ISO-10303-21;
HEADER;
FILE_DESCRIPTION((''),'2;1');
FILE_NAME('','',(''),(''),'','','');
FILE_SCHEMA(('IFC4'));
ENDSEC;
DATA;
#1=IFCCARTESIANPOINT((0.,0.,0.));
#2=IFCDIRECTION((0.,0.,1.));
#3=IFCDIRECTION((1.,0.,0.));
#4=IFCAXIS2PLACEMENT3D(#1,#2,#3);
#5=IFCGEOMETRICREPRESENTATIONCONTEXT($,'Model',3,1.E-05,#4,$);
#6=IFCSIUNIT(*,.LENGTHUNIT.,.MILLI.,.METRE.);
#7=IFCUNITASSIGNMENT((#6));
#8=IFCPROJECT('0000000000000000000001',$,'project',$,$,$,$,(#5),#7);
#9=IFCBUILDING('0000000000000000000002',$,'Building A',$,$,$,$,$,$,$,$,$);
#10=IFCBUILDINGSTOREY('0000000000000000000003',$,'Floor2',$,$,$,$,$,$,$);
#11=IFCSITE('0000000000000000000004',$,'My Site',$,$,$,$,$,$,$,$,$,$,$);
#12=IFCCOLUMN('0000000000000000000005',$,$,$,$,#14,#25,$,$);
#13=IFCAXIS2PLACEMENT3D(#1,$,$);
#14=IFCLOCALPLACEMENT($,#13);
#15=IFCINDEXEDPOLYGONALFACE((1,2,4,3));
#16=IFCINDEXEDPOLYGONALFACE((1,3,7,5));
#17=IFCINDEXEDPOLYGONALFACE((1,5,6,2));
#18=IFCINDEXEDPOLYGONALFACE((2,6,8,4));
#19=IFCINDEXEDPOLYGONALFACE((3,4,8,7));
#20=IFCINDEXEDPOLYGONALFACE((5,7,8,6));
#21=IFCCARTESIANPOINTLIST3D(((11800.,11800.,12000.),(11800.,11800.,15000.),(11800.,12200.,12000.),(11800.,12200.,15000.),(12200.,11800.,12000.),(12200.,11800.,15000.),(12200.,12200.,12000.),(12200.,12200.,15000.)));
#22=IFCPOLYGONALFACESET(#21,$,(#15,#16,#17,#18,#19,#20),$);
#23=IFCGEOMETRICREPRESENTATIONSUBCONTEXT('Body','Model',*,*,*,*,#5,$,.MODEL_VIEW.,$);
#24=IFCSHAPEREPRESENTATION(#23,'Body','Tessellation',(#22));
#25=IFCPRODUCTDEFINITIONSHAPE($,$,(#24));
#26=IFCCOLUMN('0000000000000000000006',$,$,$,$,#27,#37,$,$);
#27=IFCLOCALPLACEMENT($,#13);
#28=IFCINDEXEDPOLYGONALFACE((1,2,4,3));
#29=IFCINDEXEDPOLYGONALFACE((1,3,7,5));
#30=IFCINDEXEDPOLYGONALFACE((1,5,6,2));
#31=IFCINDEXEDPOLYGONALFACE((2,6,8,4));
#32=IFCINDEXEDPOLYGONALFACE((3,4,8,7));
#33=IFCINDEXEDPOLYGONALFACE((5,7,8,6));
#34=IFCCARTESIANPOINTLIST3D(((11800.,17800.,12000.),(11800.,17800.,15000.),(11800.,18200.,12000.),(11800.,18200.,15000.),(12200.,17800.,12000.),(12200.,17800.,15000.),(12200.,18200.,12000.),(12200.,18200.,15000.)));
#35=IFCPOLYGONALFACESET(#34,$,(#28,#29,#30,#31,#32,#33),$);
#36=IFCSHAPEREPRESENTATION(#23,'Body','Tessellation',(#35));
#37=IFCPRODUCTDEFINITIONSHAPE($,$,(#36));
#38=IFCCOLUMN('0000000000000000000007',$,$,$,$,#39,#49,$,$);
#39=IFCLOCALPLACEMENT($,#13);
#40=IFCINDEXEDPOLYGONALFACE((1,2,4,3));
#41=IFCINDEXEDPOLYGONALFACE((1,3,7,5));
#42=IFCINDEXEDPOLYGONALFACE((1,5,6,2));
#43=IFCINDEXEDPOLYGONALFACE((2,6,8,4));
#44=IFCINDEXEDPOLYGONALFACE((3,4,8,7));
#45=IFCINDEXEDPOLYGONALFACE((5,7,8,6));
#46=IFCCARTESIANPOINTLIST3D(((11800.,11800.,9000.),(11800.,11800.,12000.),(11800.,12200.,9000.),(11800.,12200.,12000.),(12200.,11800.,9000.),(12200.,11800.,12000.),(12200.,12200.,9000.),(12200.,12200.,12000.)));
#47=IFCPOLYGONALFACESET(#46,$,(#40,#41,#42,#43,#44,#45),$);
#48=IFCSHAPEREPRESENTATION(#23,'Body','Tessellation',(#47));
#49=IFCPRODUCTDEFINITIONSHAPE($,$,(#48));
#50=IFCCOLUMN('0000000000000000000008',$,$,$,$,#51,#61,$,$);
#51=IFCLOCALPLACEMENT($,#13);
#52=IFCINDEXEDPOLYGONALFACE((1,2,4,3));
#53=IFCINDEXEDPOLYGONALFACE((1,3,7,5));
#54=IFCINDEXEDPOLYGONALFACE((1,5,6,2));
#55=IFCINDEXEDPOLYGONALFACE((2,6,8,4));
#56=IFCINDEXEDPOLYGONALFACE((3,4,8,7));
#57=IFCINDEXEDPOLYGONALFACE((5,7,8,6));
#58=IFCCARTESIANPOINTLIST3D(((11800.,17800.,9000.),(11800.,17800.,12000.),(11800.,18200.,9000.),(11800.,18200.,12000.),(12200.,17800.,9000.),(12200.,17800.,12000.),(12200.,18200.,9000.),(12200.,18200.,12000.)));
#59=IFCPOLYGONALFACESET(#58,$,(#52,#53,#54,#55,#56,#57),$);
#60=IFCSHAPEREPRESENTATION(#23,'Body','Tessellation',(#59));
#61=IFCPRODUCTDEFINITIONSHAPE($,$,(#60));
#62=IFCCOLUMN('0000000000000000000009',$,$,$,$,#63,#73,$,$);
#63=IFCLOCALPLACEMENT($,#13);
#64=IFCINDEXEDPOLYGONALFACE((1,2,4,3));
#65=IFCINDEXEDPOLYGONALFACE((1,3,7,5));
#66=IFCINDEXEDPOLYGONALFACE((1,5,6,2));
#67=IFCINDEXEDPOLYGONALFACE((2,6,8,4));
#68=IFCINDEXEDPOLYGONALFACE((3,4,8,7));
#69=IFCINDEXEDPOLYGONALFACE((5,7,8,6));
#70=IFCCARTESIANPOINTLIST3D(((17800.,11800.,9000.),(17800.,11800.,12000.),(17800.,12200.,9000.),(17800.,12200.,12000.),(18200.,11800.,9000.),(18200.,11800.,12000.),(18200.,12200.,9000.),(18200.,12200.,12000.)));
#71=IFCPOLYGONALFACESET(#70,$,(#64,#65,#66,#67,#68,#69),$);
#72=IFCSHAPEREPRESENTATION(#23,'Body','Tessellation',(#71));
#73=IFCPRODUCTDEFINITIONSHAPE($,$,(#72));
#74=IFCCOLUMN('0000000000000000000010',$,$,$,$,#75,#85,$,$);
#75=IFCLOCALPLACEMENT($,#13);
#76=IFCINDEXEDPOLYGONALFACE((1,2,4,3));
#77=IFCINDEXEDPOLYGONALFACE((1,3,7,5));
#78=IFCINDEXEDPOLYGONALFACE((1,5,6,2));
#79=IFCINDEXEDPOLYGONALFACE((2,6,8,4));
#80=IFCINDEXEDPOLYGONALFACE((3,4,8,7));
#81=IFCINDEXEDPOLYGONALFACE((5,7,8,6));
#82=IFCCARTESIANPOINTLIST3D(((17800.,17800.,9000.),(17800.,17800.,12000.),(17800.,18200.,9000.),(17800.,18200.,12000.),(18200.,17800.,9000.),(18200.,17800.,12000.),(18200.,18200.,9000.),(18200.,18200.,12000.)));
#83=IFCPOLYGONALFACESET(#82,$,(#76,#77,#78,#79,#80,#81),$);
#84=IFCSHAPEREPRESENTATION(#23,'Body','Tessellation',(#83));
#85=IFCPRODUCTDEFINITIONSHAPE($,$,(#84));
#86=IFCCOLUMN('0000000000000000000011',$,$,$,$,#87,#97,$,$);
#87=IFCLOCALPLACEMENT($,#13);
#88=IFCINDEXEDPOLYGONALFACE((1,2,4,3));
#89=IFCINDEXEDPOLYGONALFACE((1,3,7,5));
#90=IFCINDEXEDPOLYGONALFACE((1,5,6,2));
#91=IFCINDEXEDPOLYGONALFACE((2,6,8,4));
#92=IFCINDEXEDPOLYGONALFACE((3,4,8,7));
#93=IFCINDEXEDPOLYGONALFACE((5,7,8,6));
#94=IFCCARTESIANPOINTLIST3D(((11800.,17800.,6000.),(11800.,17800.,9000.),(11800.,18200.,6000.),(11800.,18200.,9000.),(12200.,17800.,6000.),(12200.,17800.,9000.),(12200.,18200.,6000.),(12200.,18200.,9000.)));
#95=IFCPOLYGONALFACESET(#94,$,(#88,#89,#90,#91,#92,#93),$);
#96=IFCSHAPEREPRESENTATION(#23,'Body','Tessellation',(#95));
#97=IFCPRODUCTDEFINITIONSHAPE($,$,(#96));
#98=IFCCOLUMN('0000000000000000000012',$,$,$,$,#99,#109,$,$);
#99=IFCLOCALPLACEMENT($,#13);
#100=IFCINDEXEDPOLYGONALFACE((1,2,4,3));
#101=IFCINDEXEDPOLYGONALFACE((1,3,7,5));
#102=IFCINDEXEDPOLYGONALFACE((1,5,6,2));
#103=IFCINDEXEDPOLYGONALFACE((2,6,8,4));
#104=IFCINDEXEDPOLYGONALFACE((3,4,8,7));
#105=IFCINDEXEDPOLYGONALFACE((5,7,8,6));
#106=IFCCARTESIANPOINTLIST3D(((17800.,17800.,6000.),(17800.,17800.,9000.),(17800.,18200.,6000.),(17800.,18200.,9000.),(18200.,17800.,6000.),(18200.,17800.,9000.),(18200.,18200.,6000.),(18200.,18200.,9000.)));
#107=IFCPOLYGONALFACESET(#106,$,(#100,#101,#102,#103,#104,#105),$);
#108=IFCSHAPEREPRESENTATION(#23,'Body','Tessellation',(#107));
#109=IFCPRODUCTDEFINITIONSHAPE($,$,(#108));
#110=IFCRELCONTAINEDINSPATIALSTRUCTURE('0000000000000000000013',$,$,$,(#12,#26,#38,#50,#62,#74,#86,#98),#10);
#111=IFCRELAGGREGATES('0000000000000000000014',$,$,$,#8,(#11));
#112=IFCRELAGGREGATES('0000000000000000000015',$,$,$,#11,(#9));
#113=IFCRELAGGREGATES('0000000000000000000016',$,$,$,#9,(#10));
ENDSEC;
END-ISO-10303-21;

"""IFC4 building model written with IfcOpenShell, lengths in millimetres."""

from ifc_helpers import new_model, si_unit, frame, origin_with_axes, place, context, subcontext, project, spatial, line, indexed_curve, outline, extrude, element, save


model = new_model("IFC4")

# Units and contexts
model_context = context("Model", 3, precision=1e-05, world=origin_with_axes())
body_context = subcontext(model_context, "Body", "Model", "MODEL_VIEW")
ifc_project = project(units=[si_unit("LENGTHUNIT", "METRE", prefix="MILLI")], contexts=[model_context])

# Site, building, storey
site = spatial("IfcSite", under=ifc_project, Name="My Site")
building = spatial("IfcBuilding", under=site, Name="Building A")
storey = spatial("IfcBuildingStorey", under=building, Name="Floor2")

# Columns
for number, where, z_axis, x_axis in (
    (1, (12000.0, 12000.0, 12000.0), (0.0, 0.0, 1.0), (1.0, 0.0, 0.0)),
    (2, (12000.0, 18000.0, 12000.0), (0.0, 0.0, 1.0), (1.0, 0.0, 0.0)),
    (3, (12000.0, 12000.0, 9000.0), (0.0, 0.0, 1.0), (1.0, 0.0, 0.0)),
    (4, (12000.0, 18000.0, 9000.0), (0.0, 0.0, 1.0), (1.0, 0.0, 0.0)),
    (5, (18000.0, 12000.0, 9000.0), (0.0, 0.0, 1.0), (1.0, 0.0, 0.0)),
    (6, (18000.0, 18000.0, 9000.0), (0.0, 0.0, 1.0), (1.0, 0.0, 0.0)),
    (7, (12000.0, 18000.0, 6000.0), (0.0, 0.0, 1.0), (1.0, 0.0, 0.0)),
    (8, (18000.0, 18000.0, 6000.0), (0.0, 0.0, 1.0), (1.0, 0.0, 0.0)),
):
    element("IfcColumn", number, at=place(None, frame(where, z_axis=z_axis, x_axis=x_axis)), inside=storey, context=body_context, shape_type="SweptSolid", body=[
        extrude(outline(indexed_curve([(-200.0, -200.0), (200.0, -200.0), (200.0, 200.0), (-200.0, 200.0)], segments=[line(1, 2, 3, 4, 1)])), origin_with_axes(), (0.0, 0.0, 1.0), 3000.0),
    ])

save(model, "model.ifc")
